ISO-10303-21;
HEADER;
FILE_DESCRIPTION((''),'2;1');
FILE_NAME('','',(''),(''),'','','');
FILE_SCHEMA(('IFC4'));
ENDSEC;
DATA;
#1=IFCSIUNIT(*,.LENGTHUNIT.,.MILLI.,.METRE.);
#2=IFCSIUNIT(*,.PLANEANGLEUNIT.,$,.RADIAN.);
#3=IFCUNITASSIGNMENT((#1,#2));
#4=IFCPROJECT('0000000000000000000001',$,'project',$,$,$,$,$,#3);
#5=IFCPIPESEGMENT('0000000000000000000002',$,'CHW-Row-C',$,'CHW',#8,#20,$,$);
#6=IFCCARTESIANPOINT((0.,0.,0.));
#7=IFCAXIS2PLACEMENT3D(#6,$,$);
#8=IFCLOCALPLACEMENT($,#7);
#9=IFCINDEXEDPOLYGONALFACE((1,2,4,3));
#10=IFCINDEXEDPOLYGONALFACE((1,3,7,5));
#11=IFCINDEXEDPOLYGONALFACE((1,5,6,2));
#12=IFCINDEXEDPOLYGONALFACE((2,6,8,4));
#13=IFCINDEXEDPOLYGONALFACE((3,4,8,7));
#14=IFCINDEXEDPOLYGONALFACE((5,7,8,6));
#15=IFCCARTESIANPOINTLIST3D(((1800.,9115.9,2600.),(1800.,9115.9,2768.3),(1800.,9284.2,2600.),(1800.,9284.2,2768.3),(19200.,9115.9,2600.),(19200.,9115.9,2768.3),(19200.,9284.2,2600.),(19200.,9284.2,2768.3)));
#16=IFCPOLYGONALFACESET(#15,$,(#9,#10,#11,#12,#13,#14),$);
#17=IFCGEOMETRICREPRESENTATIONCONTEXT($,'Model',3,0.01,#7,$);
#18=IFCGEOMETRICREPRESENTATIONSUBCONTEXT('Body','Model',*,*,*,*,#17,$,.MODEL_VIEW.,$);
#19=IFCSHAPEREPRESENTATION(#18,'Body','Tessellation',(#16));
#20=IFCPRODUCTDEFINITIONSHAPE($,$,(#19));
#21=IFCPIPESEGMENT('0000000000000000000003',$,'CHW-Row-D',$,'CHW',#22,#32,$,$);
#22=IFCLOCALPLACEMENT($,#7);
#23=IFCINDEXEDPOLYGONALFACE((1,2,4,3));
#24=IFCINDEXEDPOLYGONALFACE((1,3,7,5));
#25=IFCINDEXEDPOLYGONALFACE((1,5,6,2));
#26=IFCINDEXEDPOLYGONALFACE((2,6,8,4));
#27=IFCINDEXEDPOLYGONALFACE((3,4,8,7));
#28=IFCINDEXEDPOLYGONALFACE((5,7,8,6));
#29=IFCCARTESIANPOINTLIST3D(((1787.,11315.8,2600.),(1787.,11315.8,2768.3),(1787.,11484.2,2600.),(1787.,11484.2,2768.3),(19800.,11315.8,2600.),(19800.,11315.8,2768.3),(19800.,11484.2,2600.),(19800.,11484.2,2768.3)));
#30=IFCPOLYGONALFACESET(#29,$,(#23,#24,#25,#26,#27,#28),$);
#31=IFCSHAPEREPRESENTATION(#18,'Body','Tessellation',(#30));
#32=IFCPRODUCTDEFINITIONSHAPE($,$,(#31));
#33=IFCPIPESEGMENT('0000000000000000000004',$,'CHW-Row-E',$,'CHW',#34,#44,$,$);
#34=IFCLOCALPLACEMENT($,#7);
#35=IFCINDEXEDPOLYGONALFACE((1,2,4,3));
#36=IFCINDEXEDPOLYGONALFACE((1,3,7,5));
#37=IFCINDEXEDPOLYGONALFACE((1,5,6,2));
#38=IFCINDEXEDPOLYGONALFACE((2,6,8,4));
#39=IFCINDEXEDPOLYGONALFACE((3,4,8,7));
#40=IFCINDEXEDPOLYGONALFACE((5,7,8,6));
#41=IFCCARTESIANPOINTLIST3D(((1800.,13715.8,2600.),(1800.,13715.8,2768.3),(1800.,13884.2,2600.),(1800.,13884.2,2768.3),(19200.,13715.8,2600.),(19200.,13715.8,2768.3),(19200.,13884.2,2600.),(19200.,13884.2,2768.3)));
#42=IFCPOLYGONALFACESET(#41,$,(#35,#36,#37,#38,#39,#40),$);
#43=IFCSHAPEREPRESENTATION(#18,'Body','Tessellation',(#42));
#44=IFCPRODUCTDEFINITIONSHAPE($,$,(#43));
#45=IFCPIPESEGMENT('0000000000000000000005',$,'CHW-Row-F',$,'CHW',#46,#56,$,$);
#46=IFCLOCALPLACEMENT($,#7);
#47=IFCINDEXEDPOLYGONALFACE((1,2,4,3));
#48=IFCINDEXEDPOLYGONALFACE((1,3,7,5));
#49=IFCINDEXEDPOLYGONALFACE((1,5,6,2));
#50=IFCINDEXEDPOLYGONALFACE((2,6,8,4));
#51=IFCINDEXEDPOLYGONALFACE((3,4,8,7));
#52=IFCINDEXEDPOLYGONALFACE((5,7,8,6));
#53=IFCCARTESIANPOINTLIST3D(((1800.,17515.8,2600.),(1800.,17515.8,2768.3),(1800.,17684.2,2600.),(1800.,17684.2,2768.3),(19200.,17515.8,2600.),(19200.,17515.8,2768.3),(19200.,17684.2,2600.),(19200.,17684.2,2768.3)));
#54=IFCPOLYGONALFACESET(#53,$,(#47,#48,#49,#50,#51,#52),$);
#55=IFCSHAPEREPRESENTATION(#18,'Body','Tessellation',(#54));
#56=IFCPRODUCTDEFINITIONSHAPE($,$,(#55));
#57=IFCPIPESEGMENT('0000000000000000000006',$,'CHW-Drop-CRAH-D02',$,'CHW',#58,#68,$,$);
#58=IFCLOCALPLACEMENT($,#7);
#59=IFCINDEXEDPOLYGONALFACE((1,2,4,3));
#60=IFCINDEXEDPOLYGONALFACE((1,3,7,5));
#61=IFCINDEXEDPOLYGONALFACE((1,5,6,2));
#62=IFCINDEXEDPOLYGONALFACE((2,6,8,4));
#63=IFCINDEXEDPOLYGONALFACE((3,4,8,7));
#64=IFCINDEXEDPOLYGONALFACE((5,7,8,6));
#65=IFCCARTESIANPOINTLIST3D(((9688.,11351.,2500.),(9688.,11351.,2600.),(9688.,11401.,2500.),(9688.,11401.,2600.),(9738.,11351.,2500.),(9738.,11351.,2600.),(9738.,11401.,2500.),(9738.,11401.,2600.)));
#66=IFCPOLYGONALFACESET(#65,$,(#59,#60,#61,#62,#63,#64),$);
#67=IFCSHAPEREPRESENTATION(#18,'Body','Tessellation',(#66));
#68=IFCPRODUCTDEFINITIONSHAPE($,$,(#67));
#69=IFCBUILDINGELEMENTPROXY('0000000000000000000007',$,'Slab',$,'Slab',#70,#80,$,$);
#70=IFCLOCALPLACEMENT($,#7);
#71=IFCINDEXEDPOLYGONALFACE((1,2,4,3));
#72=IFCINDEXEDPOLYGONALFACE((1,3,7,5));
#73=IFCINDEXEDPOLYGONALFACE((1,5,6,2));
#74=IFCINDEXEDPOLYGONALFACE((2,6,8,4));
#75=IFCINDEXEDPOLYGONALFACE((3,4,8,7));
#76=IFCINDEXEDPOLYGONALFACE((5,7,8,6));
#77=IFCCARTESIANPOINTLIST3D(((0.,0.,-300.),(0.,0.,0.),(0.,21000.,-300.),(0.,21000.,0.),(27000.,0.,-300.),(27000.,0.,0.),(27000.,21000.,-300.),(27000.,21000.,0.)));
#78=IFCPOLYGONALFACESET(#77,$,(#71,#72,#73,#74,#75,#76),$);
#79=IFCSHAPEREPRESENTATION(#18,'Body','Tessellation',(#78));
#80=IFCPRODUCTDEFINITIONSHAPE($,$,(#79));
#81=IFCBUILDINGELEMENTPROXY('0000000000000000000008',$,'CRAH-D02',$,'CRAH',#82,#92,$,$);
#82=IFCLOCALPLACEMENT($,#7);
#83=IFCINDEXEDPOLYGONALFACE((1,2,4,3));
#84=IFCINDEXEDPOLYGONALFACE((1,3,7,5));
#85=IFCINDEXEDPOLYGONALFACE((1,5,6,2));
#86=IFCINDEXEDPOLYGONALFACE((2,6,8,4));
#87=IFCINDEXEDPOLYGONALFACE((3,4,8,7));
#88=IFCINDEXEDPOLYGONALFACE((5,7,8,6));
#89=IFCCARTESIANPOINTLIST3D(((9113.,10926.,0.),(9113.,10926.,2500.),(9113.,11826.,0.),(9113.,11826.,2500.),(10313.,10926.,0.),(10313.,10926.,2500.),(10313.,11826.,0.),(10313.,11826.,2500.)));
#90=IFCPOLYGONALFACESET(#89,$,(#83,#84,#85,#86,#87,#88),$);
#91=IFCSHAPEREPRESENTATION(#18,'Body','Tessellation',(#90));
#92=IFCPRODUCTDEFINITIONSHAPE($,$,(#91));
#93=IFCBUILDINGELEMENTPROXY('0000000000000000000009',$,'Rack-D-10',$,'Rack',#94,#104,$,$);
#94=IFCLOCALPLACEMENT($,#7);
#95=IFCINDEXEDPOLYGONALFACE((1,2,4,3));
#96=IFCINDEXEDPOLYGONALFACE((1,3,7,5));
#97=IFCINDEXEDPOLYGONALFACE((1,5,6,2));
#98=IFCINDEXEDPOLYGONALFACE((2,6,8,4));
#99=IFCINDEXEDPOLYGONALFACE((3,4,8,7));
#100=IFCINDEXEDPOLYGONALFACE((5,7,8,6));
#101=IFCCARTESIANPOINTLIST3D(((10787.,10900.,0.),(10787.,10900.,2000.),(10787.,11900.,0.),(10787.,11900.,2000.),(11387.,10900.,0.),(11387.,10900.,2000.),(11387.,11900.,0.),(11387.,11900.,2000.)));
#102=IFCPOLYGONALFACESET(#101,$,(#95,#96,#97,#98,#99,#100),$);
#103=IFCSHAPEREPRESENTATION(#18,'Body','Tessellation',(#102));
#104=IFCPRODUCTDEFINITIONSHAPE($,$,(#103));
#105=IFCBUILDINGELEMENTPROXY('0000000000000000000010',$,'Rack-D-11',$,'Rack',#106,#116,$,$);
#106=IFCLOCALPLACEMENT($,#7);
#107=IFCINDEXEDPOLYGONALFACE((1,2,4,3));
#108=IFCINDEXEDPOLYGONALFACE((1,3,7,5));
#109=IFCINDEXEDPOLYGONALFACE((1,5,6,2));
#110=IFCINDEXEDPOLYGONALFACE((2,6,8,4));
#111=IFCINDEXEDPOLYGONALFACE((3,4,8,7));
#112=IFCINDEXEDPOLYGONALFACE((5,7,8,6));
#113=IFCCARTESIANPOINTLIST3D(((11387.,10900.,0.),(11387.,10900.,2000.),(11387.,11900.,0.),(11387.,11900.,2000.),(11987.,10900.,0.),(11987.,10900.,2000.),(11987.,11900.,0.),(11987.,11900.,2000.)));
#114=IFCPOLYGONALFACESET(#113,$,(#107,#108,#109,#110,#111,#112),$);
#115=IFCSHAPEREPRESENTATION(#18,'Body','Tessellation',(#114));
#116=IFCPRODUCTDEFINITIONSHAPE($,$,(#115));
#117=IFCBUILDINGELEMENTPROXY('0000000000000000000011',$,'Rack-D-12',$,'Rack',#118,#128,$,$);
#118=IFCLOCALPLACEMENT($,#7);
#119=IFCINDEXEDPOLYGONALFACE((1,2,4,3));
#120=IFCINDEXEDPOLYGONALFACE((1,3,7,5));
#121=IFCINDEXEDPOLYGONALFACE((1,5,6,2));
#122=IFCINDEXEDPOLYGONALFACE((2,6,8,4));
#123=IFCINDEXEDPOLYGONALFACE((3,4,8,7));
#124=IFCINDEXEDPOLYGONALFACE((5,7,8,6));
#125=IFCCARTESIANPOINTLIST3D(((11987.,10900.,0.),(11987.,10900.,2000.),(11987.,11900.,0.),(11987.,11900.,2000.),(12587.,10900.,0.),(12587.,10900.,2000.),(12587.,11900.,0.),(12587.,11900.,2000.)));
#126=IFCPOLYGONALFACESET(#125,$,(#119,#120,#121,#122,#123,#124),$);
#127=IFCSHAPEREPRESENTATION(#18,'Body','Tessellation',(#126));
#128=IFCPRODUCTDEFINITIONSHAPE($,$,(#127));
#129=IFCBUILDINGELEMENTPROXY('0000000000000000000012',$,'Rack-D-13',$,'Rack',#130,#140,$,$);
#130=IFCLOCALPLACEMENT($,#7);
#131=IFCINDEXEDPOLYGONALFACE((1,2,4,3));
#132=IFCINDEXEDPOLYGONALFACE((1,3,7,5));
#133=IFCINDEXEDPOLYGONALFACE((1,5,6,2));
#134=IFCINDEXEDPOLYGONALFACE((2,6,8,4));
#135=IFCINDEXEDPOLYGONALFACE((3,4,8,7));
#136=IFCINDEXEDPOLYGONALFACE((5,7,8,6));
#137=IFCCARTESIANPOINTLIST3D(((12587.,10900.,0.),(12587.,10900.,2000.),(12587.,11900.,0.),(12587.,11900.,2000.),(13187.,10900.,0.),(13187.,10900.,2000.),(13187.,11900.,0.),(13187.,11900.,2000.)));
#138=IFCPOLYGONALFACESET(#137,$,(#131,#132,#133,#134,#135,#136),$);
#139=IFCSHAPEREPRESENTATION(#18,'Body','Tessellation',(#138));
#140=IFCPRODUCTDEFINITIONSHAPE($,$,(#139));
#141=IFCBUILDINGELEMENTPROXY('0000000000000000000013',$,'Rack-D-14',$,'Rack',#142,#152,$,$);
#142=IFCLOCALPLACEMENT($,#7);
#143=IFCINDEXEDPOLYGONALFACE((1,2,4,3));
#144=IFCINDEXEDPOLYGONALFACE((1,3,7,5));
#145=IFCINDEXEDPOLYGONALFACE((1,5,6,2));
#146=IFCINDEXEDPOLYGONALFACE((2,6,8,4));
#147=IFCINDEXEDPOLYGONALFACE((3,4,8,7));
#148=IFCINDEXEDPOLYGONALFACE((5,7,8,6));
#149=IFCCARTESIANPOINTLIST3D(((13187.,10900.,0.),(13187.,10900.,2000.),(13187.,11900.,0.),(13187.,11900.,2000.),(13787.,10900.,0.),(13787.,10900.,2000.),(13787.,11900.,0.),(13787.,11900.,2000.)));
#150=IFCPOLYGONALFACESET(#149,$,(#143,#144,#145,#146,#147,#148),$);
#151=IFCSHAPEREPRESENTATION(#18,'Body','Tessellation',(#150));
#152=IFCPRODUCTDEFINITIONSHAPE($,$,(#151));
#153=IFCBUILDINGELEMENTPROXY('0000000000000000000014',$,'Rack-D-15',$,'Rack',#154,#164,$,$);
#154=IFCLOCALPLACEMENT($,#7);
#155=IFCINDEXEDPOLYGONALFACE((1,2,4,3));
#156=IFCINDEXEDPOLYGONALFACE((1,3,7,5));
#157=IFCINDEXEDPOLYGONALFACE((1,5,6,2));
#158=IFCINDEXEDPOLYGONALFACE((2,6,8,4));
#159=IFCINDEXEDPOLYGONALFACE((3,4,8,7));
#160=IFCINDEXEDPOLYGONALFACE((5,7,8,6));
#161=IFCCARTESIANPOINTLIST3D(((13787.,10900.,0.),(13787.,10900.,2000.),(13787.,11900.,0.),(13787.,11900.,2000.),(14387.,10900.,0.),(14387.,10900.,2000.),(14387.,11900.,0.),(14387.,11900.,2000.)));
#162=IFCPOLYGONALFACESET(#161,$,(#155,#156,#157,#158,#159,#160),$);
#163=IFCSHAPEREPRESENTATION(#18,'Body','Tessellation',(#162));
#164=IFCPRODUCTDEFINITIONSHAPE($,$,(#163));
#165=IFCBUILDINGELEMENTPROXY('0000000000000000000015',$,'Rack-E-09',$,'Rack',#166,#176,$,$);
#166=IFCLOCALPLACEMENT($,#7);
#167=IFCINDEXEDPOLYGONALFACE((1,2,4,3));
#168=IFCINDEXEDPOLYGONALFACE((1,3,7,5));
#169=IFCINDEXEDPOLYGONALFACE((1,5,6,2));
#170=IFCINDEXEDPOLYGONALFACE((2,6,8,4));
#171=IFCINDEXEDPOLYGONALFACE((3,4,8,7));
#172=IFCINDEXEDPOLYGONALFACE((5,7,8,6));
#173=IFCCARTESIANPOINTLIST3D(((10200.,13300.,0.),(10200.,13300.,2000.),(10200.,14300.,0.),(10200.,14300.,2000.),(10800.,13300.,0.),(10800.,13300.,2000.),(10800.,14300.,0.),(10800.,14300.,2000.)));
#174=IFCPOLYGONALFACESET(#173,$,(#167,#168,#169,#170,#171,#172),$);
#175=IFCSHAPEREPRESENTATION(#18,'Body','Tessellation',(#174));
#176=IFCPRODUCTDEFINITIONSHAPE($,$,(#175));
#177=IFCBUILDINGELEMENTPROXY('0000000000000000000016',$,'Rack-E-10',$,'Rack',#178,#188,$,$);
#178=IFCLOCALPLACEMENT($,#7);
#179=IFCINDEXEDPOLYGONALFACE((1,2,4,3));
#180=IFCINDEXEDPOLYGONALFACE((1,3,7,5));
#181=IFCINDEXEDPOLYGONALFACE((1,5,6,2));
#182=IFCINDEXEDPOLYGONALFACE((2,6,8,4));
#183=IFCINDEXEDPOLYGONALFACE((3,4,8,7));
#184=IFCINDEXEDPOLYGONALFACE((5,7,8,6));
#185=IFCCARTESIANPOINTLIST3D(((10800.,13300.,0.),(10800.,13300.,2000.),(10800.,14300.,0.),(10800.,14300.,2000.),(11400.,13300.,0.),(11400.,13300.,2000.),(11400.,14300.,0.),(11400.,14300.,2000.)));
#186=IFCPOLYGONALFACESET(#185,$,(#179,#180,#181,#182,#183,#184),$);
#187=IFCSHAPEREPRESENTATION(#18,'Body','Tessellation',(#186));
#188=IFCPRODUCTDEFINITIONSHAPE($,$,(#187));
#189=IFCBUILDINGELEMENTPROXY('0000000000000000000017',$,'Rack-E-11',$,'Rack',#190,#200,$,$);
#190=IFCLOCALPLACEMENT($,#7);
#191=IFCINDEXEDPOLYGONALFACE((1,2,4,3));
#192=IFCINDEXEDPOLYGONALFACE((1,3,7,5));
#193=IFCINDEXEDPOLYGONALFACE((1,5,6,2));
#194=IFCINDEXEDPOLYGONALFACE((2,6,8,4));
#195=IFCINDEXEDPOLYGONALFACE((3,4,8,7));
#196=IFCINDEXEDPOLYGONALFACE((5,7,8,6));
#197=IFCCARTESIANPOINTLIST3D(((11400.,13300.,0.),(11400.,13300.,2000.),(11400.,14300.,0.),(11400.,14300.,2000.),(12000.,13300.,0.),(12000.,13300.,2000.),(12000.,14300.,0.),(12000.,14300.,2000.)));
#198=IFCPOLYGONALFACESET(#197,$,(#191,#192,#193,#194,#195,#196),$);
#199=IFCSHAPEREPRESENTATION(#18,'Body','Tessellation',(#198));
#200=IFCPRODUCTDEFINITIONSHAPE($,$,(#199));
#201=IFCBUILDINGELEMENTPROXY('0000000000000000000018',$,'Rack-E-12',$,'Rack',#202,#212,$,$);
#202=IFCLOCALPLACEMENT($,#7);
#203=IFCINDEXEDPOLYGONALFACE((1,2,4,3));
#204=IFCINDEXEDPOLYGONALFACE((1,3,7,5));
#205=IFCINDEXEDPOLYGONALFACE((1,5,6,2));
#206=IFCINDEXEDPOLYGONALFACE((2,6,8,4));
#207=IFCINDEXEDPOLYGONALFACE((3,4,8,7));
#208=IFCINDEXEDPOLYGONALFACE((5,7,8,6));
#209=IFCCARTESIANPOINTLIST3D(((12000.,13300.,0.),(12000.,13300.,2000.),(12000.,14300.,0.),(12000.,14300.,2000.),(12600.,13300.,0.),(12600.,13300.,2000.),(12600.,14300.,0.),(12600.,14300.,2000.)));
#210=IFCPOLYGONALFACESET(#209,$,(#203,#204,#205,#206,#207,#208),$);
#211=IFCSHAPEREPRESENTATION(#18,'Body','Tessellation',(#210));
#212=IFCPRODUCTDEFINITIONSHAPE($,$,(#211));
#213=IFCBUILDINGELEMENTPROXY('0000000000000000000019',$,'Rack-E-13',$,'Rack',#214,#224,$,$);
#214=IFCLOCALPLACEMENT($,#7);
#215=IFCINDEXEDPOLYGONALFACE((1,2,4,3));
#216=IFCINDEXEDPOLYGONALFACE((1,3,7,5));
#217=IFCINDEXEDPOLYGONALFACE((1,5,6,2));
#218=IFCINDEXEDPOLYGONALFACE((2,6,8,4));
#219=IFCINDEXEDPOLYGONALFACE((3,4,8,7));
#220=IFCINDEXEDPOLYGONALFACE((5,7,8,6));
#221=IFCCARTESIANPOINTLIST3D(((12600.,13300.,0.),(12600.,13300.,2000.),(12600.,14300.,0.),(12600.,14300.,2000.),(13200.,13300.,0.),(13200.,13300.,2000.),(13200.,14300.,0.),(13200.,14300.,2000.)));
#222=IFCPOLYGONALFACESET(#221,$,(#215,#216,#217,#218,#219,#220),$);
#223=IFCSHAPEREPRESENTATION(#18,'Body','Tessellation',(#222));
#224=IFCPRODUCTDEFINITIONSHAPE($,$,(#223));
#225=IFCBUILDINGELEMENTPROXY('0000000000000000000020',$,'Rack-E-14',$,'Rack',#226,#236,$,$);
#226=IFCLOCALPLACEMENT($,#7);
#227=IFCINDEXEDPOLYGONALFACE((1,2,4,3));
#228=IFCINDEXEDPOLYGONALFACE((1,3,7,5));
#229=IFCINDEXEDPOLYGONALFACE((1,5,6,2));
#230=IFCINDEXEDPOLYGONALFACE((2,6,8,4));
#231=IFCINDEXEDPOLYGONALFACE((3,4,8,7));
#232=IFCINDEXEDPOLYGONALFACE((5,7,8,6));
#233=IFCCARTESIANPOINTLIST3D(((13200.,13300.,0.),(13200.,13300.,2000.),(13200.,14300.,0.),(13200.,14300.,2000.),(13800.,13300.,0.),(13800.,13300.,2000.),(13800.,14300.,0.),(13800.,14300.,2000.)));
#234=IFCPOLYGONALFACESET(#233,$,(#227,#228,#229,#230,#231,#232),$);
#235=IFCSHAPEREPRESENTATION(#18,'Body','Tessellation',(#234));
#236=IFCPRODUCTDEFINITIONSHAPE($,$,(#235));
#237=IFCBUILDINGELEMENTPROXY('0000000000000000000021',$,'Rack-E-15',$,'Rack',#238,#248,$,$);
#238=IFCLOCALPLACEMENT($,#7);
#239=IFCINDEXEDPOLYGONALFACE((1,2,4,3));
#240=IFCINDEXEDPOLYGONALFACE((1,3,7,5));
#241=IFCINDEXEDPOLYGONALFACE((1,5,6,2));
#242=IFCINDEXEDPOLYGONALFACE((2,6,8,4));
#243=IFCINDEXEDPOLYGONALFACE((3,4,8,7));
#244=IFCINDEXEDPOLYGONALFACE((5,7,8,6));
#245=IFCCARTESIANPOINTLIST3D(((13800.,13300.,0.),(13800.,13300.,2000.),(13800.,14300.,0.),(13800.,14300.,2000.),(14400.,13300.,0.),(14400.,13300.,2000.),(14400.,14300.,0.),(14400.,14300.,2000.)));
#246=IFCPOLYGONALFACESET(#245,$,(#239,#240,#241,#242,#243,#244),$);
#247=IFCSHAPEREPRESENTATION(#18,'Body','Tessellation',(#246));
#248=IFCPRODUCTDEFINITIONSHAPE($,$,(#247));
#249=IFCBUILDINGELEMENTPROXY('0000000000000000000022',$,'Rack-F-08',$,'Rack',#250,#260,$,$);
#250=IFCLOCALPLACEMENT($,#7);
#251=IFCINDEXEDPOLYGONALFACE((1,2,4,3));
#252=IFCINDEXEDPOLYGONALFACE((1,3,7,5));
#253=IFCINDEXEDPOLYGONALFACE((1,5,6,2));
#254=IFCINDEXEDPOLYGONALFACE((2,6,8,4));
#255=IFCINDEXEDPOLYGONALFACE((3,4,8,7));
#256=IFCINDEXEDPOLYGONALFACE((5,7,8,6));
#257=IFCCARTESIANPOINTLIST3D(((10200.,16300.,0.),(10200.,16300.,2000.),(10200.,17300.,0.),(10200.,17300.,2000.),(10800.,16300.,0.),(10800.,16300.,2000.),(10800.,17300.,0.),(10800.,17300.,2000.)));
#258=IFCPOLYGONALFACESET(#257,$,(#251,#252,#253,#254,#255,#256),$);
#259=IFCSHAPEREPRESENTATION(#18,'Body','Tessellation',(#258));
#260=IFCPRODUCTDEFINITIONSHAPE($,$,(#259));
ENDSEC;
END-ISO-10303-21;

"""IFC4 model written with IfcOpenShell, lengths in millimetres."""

from ifc_helpers import new_model, si_unit, frame, origin, place, context, subcontext, project, rectangle, extrude, element, save


model = new_model("IFC4")

# Units and contexts
model_context = context("Model", 3, precision=0.01, world=origin())
body_context = subcontext(model_context, "Body", "Model", "MODEL_VIEW")
ifc_project = project(units=[si_unit("LENGTHUNIT", "METRE", prefix="MILLI"), si_unit("PLANEANGLEUNIT", "RADIAN")])

# Pipe segments
placement = place(None, origin())
pipe_segment_1_placement = place(placement, frame((10500.0, 9200.0, 2600.0)))
element("IfcPipeSegment", 1, at=pipe_segment_1_placement, Name="CHW-Row-C", ObjectType="CHW", context=body_context, shape_type="SweptSolid", body=[
    extrude(rectangle(XDim=17400.0, YDim=168.3), origin(), (0.0, 0.0, 1.0), 168.3),
])
pipe_segment_2_placement = place(placement, frame((10793.5, 11400.0, 2600.0)))
element("IfcPipeSegment", 2, at=pipe_segment_2_placement, Name="CHW-Row-D", ObjectType="CHW", context=body_context, shape_type="SweptSolid", body=[
    extrude(rectangle(XDim=18013.0, YDim=168.3), origin(), (0.0, 0.0, 1.0), 168.3),
])
for number, where, name in (
    (3, (10500.0, 13800.0, 2600.0), "CHW-Row-E"),
    (4, (10500.0, 17600.0, 2600.0), "CHW-Row-F"),
):
    element("IfcPipeSegment", number, at=place(placement, frame(where)), Name=name, ObjectType="CHW", context=body_context, shape_type="SweptSolid", body=[
        extrude(rectangle(XDim=17400.0, YDim=168.3), origin(), (0.0, 0.0, 1.0), 168.3),
    ])
pipe_segment_3_placement = place(placement, frame((9713.0, 11376.0, 2500.0)))
element("IfcPipeSegment", 5, at=pipe_segment_3_placement, Name="CHW-Drop-CRAH-D02", ObjectType="CHW", context=body_context, shape_type="SweptSolid", body=[
    extrude(rectangle(XDim=50.0, YDim=50.0), origin(), (0.0, 0.0, 1.0), 100.0),
])

# Building element proxies
proxy_1_placement = place(placement, frame((13500.0, 10500.0, -300.0)))
element("IfcBuildingElementProxy", 6, at=proxy_1_placement, Name="Slab", ObjectType="Slab", context=body_context, shape_type="SweptSolid", body=[
    extrude(rectangle(XDim=27000.0, YDim=21000.0), origin(), (0.0, 0.0, 1.0), 300.0),
])
proxy_2_placement = place(placement, frame((9713.0, 11376.0, 0.0)))
element("IfcBuildingElementProxy", 7, at=proxy_2_placement, Name="CRAH-D02", ObjectType="CRAH", context=body_context, shape_type="SweptSolid", body=[
    extrude(rectangle(XDim=1200.0, YDim=900.0), origin(), (0.0, 0.0, 1.0), 2500.0),
])
for number, where, name in (
    (8, (11087.0, 11400.0, 0.0), "Rack-D-10"),
    (9, (11687.0, 11400.0, 0.0), "Rack-D-11"),
    (10, (12287.0, 11400.0, 0.0), "Rack-D-12"),
    (11, (12887.0, 11400.0, 0.0), "Rack-D-13"),
    (12, (13487.0, 11400.0, 0.0), "Rack-D-14"),
    (13, (14087.0, 11400.0, 0.0), "Rack-D-15"),
    (14, (10500.0, 13800.0, 0.0), "Rack-E-09"),
    (15, (11100.0, 13800.0, 0.0), "Rack-E-10"),
    (16, (11700.0, 13800.0, 0.0), "Rack-E-11"),
    (17, (12300.0, 13800.0, 0.0), "Rack-E-12"),
    (18, (12900.0, 13800.0, 0.0), "Rack-E-13"),
    (19, (13500.0, 13800.0, 0.0), "Rack-E-14"),
    (20, (14100.0, 13800.0, 0.0), "Rack-E-15"),
    (21, (10500.0, 16800.0, 0.0), "Rack-F-08"),
):
    element("IfcBuildingElementProxy", number, at=place(placement, frame(where)), Name=name, ObjectType="Rack", context=body_context, shape_type="SweptSolid", body=[
        extrude(rectangle(XDim=600.0, YDim=1000.0), origin(), (0.0, 0.0, 1.0), 2000.0),
    ])

save(model, "model.ifc")
